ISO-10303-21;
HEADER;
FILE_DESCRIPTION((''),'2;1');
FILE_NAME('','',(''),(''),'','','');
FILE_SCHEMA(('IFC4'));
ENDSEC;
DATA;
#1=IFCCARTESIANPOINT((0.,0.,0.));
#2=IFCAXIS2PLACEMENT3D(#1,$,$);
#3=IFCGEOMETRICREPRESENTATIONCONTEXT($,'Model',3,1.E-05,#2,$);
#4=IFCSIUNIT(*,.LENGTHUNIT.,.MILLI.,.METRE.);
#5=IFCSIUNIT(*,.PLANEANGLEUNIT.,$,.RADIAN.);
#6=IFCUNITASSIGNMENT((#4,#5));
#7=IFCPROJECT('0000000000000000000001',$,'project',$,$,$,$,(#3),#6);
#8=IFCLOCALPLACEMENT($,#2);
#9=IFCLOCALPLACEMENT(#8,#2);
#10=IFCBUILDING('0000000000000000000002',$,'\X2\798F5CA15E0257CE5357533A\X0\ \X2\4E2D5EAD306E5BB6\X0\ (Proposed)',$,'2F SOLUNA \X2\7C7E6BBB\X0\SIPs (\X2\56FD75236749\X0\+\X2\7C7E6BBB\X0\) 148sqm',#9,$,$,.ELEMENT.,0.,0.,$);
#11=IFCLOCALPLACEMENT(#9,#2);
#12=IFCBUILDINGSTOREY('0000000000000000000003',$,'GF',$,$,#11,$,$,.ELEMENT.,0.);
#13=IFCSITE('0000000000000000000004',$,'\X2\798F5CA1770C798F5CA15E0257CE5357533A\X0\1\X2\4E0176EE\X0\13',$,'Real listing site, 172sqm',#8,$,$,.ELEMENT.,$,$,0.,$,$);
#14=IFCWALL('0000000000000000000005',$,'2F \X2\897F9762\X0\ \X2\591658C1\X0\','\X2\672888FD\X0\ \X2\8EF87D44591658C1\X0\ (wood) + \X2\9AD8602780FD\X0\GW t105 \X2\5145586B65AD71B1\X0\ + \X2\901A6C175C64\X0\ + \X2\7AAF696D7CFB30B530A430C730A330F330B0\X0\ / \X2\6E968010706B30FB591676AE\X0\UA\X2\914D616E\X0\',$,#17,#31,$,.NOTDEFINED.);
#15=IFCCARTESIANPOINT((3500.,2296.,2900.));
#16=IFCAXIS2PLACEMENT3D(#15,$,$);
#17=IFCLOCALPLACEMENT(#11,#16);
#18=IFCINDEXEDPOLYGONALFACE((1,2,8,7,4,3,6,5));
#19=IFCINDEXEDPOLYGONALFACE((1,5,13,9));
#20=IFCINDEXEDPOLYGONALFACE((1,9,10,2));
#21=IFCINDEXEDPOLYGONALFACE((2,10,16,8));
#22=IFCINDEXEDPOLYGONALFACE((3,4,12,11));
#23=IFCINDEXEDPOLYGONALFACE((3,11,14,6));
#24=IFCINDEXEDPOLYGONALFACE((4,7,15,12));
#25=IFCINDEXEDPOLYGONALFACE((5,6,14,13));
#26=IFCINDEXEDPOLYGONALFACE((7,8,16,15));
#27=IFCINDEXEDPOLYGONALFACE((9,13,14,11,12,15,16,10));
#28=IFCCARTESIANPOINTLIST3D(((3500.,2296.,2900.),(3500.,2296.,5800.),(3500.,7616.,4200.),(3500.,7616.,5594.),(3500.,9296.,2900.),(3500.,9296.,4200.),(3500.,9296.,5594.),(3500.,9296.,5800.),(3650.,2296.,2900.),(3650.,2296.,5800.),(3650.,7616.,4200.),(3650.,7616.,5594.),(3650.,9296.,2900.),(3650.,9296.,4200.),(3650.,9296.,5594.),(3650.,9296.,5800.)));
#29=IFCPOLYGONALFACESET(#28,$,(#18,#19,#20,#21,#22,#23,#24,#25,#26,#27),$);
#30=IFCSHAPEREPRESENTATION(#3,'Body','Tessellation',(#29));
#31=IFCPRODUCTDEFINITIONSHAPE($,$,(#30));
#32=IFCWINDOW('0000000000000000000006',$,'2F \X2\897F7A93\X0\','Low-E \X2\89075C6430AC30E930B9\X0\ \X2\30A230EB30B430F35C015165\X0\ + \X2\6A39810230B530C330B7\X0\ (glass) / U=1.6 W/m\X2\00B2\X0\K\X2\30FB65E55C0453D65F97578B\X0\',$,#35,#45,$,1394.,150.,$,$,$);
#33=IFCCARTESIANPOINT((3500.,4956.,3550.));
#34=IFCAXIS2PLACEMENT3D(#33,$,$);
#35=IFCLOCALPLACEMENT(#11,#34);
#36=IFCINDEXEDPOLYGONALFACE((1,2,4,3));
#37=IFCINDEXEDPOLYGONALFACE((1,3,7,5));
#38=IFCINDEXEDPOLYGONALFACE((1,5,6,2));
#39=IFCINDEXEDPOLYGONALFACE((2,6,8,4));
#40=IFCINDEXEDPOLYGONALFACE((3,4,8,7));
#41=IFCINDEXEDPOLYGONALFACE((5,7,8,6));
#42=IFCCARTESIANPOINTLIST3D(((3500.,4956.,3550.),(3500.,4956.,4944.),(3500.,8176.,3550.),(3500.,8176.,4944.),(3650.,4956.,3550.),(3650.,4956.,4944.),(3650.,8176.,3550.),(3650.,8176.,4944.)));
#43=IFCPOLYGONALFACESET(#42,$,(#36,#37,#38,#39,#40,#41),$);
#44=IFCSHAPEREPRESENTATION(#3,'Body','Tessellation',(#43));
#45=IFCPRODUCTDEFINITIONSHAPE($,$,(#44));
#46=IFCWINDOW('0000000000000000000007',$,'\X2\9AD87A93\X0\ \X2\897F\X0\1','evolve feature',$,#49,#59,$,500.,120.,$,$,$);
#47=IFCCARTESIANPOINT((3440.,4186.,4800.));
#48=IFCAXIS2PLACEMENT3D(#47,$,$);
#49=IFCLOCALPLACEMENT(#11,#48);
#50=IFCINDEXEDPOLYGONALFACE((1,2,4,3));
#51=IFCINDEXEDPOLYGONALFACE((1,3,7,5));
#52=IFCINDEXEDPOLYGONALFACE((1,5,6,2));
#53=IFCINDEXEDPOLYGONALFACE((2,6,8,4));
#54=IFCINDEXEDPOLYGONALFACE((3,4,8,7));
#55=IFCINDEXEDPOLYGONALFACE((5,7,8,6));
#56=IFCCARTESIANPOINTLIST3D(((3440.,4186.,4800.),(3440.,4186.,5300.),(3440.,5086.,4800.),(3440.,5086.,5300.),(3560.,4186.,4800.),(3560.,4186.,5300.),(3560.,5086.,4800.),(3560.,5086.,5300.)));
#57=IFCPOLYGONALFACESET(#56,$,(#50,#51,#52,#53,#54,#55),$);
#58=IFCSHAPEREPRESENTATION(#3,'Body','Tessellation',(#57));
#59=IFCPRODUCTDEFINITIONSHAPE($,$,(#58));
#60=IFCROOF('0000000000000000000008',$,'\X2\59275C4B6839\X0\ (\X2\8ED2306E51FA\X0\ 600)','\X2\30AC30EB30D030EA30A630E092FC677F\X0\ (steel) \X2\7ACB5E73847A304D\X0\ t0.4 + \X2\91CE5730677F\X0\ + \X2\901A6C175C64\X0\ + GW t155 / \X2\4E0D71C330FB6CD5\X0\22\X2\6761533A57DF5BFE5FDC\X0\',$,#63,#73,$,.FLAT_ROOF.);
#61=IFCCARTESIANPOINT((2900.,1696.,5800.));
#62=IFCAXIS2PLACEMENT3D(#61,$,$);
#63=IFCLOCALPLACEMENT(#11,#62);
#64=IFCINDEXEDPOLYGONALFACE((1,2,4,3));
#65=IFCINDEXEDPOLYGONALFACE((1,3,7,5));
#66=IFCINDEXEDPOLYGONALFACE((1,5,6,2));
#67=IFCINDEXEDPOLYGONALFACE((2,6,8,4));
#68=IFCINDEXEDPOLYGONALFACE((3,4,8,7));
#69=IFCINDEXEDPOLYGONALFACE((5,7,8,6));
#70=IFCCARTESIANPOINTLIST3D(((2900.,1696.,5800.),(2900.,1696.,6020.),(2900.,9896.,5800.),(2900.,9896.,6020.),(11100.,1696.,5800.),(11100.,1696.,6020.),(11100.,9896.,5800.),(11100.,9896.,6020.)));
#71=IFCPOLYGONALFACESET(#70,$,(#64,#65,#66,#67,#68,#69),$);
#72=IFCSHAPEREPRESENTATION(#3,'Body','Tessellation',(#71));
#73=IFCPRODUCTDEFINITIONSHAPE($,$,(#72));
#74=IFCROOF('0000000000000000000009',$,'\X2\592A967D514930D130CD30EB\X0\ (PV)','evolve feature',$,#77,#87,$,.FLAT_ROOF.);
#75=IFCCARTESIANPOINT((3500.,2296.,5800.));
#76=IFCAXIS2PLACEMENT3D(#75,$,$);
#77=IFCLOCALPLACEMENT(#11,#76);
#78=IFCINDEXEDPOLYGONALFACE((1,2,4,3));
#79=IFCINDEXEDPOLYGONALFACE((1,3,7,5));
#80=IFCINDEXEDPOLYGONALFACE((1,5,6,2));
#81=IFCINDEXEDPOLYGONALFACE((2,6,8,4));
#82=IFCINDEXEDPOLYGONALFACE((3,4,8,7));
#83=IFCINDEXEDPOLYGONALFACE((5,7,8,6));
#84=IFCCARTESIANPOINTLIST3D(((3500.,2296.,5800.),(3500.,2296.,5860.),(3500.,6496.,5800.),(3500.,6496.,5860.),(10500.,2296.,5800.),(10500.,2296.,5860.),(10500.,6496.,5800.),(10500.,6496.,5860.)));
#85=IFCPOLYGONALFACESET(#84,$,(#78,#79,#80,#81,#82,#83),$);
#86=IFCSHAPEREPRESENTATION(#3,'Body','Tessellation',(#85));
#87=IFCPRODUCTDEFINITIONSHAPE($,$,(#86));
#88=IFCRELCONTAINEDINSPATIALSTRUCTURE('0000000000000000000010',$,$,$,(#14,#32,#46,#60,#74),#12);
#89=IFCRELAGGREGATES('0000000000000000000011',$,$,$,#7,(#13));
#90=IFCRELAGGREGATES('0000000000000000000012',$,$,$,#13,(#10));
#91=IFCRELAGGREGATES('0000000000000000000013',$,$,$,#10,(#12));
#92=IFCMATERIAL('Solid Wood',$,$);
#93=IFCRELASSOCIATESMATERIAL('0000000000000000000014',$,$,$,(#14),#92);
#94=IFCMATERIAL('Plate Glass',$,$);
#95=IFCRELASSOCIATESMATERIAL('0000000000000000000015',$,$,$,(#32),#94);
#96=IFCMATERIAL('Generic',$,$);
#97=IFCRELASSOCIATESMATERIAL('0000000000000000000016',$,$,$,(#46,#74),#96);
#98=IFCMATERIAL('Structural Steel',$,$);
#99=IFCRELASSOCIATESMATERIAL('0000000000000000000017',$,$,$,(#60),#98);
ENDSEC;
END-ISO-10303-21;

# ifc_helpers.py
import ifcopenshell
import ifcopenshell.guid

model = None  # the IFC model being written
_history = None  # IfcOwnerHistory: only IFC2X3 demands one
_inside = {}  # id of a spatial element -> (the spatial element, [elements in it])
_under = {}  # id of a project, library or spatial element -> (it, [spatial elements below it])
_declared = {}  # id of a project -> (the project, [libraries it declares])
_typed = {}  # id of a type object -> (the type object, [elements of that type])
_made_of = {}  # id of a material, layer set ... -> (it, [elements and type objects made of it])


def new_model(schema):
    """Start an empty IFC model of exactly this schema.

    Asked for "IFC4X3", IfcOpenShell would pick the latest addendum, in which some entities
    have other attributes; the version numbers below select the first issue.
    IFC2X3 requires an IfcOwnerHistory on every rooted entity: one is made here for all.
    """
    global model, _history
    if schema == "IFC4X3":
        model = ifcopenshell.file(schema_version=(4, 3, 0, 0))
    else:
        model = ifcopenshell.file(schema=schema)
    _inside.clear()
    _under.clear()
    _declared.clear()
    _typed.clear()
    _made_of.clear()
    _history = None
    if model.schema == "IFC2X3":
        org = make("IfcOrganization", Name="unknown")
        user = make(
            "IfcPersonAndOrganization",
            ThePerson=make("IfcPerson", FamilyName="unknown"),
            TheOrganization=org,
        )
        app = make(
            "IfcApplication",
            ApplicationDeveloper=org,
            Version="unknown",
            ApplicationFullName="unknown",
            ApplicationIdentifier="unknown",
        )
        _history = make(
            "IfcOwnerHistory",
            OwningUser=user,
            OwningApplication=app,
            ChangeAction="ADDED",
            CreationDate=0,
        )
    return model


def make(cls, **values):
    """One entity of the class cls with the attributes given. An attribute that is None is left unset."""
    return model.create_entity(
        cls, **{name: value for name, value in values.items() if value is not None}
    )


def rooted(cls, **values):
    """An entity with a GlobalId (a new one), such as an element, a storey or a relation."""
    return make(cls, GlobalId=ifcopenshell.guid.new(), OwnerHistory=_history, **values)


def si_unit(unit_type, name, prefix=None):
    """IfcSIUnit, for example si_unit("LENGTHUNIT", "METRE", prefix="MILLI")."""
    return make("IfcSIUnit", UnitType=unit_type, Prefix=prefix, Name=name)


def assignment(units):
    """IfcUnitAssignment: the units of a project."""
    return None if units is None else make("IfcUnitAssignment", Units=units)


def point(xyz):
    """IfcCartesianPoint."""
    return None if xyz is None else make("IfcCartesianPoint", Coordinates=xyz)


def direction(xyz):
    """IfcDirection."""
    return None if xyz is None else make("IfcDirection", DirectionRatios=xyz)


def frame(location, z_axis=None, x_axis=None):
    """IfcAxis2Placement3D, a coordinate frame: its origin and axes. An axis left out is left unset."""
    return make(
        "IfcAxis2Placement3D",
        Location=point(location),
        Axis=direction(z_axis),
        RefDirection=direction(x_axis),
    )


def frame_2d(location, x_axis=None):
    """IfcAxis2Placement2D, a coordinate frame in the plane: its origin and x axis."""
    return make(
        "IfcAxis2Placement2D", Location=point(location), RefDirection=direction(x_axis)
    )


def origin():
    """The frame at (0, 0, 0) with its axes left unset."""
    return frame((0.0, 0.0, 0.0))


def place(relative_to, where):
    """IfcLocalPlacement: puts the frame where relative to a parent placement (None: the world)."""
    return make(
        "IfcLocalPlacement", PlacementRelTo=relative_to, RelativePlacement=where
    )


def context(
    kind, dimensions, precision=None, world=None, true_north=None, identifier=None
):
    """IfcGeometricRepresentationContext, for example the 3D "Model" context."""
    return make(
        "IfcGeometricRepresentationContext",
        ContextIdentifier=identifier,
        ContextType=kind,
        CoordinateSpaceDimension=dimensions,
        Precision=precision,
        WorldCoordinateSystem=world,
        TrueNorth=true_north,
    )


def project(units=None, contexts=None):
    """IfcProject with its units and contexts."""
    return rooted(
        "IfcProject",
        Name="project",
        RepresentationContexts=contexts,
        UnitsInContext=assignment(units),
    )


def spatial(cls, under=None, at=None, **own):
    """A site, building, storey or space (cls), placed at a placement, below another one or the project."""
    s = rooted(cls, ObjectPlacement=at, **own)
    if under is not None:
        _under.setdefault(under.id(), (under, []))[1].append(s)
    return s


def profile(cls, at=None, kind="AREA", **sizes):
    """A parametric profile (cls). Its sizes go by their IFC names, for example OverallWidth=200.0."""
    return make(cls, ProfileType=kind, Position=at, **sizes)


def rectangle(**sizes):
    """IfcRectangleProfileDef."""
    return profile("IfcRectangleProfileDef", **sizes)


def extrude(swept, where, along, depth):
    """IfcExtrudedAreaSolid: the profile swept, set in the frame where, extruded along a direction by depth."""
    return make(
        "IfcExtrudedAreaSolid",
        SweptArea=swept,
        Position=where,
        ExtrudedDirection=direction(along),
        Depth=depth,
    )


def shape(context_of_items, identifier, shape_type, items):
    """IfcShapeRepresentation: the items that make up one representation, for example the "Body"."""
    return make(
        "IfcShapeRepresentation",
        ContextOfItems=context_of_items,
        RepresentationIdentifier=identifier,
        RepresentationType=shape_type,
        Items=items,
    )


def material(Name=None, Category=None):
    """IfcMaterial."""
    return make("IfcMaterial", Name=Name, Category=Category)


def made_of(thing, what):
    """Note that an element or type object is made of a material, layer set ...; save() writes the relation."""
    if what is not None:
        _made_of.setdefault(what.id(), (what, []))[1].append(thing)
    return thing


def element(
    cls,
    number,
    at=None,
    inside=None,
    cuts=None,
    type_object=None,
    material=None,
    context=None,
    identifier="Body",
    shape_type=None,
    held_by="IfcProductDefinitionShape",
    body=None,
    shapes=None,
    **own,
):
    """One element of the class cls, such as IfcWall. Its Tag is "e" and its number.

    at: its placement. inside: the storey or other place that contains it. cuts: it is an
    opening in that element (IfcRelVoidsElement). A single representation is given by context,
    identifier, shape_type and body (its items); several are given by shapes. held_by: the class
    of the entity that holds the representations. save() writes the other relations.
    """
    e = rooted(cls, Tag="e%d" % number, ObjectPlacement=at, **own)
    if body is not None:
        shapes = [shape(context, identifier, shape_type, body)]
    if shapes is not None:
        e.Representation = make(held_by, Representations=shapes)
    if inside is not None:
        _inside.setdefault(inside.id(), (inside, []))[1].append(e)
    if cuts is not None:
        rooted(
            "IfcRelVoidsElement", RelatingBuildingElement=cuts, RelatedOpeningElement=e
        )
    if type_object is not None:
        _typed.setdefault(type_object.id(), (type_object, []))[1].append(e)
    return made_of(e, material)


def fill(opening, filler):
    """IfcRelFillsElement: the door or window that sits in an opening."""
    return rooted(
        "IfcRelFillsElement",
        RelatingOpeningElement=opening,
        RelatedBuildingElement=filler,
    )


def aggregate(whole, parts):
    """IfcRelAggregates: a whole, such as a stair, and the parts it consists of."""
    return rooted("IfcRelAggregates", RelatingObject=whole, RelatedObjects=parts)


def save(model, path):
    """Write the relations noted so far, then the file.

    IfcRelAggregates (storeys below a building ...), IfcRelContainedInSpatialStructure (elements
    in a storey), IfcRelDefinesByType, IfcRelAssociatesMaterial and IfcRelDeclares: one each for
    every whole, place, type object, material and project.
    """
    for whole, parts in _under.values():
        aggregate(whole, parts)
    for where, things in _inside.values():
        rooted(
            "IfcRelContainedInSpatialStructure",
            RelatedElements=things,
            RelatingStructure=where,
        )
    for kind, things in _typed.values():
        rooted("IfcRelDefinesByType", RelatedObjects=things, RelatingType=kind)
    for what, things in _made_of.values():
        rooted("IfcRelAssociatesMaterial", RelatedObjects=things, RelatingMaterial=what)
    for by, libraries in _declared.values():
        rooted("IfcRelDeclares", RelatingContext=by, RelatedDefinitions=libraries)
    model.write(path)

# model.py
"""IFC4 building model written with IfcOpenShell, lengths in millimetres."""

from ifc_helpers import new_model, si_unit, frame, frame_2d, origin, place, context, project, spatial, rectangle, extrude, material, element, fill, save


model = new_model("IFC4")

# Units and contexts
model_context = context("Model", 3, precision=1e-05, world=origin())
ifc_project = project(units=[si_unit("LENGTHUNIT", "METRE", prefix="MILLI"), si_unit("PLANEANGLEUNIT", "RADIAN")], contexts=[model_context])

# Site, building, storey
site_placement = place(None, origin())
site = spatial("IfcSite", under=ifc_project, at=site_placement, Name="福岡県福岡市城南区1丁目13", ObjectType="Real listing site, 172sqm", CompositionType="ELEMENT", RefElevation=0.0)
building_placement = place(site_placement, origin())
building = spatial("IfcBuilding", under=site, at=building_placement, Name="福岡市城南区 中庭の家 (Proposed)", ObjectType="2F SOLUNA 籾殻SIPs (国産杉+籾殻) 148sqm", CompositionType="ELEMENT", ElevationOfRefHeight=0.0, ElevationOfTerrain=0.0)
storey_placement = place(building_placement, origin())
storey = spatial("IfcBuildingStorey", under=building, at=storey_placement, Name="GF", CompositionType="ELEMENT", Elevation=0.0)

# Shared definitions
ifc_material_1 = material(Name="Solid Wood")
ifc_material_2 = material(Name="Generic")

# Shared definitions
ifc_material_3 = material(Name="Plate Glass")

# Wall, openings, windows
wall_1_placement = place(storey_placement, frame((3500.0, 2296.0, 2900.0)))
wall_1 = element("IfcWall", 1, at=wall_1_placement, inside=storey, material=ifc_material_1, Name="2F 西面 外壁", Description="木製 軸組外壁 (wood) + 高性能GW t105 充填断熱 + 通気層 + 窯業系サイディング / 準耐火・外皮UA配慮", PredefinedType="NOTDEFINED", context=model_context, shape_type="SweptSolid", body=[
    extrude(rectangle(XDim=150.0, YDim=7000.0, at=frame_2d((75.0, 3500.0))), frame((3500.0, 2296.0, 2900.0)), (0.0, 0.0, 1.0), 2900.0),
])
opening_1_placement = place(storey_placement, frame((3500.0, 4956.0, 3550.0)))
opening_1 = element("IfcOpeningElement", 2, at=opening_1_placement, cuts=wall_1, PredefinedType="NOTDEFINED", context=model_context, shape_type="SweptSolid", body=[
    extrude(rectangle(XDim=150.0, YDim=3220.0, at=frame_2d((75.0, 1610.0))), frame((3500.0, 4956.0, 3550.0)), (0.0, 0.0, 1.0), 1394.0),
])
opening_2_placement = place(storey_placement, frame((3440.0, 4186.0, 4800.0)))
opening_2 = element("IfcOpeningElement", 3, at=opening_2_placement, cuts=wall_1, PredefinedType="NOTDEFINED", context=model_context, shape_type="SweptSolid", body=[
    extrude(rectangle(XDim=120.0, YDim=900.0, at=frame_2d((60.0, 450.0))), frame((3440.0, 4186.0, 4800.0)), (0.0, 0.0, 1.0), 500.0),
])
window_1_placement = place(storey_placement, frame((3500.0, 4956.0, 3550.0)))
window_1 = element("IfcWindow", 4, at=window_1_placement, inside=storey, material=ifc_material_3, Name="2F 西窓", Description="Low-E 複層ガラス アルゴン封入 + 樹脂サッシ (glass) / U=1.6 W/m²K・日射取得型", OverallHeight=1394.0, OverallWidth=150.0, context=model_context, shape_type="SweptSolid", body=[
    extrude(rectangle(XDim=150.0, YDim=3220.0, at=frame_2d((75.0, 1610.0))), frame((3500.0, 4956.0, 3550.0)), (0.0, 0.0, 1.0), 1394.0),
])
fill(opening_1, window_1)
window_2_placement = place(storey_placement, frame((3440.0, 4186.0, 4800.0)))
window_2 = element("IfcWindow", 5, at=window_2_placement, inside=storey, material=ifc_material_2, Name="高窓 西1", Description="evolve feature", OverallHeight=500.0, OverallWidth=120.0, context=model_context, shape_type="SweptSolid", body=[
    extrude(rectangle(XDim=120.0, YDim=900.0, at=frame_2d((60.0, 450.0))), frame((3440.0, 4186.0, 4800.0)), (0.0, 0.0, 1.0), 500.0),
])
fill(opening_2, window_2)

# Roofs
ifc_material_4 = material(Name="Structural Steel")
roof_1_placement = place(storey_placement, frame((2900.0, 1696.0, 5800.0)))
element("IfcRoof", 6, at=roof_1_placement, inside=storey, material=ifc_material_4, Name="大屋根 (軒の出 600)", Description="ガルバリウム鋼板 (steel) 立平葺き t0.4 + 野地板 + 通気層 + GW t155 / 不燃・法22条区域対応", PredefinedType="FLAT_ROOF", context=model_context, shape_type="SweptSolid", body=[
    extrude(rectangle(XDim=8200.0, YDim=8200.0, at=frame_2d((4100.0, 4100.0))), frame((2900.0, 1696.0, 5800.0)), (0.0, 0.0, 1.0), 220.0),
])
roof_2_placement = place(storey_placement, frame((3500.0, 2296.0, 5800.0)))
element("IfcRoof", 7, at=roof_2_placement, inside=storey, material=ifc_material_2, Name="太陽光パネル (PV)", Description="evolve feature", PredefinedType="FLAT_ROOF", context=model_context, shape_type="SweptSolid", body=[
    extrude(rectangle(XDim=7000.0, YDim=4200.0, at=frame_2d((3500.0, 2100.0))), frame((3500.0, 2296.0, 5800.0)), (0.0, 0.0, 1.0), 60.0),
])

save(model, "model.ifc")
